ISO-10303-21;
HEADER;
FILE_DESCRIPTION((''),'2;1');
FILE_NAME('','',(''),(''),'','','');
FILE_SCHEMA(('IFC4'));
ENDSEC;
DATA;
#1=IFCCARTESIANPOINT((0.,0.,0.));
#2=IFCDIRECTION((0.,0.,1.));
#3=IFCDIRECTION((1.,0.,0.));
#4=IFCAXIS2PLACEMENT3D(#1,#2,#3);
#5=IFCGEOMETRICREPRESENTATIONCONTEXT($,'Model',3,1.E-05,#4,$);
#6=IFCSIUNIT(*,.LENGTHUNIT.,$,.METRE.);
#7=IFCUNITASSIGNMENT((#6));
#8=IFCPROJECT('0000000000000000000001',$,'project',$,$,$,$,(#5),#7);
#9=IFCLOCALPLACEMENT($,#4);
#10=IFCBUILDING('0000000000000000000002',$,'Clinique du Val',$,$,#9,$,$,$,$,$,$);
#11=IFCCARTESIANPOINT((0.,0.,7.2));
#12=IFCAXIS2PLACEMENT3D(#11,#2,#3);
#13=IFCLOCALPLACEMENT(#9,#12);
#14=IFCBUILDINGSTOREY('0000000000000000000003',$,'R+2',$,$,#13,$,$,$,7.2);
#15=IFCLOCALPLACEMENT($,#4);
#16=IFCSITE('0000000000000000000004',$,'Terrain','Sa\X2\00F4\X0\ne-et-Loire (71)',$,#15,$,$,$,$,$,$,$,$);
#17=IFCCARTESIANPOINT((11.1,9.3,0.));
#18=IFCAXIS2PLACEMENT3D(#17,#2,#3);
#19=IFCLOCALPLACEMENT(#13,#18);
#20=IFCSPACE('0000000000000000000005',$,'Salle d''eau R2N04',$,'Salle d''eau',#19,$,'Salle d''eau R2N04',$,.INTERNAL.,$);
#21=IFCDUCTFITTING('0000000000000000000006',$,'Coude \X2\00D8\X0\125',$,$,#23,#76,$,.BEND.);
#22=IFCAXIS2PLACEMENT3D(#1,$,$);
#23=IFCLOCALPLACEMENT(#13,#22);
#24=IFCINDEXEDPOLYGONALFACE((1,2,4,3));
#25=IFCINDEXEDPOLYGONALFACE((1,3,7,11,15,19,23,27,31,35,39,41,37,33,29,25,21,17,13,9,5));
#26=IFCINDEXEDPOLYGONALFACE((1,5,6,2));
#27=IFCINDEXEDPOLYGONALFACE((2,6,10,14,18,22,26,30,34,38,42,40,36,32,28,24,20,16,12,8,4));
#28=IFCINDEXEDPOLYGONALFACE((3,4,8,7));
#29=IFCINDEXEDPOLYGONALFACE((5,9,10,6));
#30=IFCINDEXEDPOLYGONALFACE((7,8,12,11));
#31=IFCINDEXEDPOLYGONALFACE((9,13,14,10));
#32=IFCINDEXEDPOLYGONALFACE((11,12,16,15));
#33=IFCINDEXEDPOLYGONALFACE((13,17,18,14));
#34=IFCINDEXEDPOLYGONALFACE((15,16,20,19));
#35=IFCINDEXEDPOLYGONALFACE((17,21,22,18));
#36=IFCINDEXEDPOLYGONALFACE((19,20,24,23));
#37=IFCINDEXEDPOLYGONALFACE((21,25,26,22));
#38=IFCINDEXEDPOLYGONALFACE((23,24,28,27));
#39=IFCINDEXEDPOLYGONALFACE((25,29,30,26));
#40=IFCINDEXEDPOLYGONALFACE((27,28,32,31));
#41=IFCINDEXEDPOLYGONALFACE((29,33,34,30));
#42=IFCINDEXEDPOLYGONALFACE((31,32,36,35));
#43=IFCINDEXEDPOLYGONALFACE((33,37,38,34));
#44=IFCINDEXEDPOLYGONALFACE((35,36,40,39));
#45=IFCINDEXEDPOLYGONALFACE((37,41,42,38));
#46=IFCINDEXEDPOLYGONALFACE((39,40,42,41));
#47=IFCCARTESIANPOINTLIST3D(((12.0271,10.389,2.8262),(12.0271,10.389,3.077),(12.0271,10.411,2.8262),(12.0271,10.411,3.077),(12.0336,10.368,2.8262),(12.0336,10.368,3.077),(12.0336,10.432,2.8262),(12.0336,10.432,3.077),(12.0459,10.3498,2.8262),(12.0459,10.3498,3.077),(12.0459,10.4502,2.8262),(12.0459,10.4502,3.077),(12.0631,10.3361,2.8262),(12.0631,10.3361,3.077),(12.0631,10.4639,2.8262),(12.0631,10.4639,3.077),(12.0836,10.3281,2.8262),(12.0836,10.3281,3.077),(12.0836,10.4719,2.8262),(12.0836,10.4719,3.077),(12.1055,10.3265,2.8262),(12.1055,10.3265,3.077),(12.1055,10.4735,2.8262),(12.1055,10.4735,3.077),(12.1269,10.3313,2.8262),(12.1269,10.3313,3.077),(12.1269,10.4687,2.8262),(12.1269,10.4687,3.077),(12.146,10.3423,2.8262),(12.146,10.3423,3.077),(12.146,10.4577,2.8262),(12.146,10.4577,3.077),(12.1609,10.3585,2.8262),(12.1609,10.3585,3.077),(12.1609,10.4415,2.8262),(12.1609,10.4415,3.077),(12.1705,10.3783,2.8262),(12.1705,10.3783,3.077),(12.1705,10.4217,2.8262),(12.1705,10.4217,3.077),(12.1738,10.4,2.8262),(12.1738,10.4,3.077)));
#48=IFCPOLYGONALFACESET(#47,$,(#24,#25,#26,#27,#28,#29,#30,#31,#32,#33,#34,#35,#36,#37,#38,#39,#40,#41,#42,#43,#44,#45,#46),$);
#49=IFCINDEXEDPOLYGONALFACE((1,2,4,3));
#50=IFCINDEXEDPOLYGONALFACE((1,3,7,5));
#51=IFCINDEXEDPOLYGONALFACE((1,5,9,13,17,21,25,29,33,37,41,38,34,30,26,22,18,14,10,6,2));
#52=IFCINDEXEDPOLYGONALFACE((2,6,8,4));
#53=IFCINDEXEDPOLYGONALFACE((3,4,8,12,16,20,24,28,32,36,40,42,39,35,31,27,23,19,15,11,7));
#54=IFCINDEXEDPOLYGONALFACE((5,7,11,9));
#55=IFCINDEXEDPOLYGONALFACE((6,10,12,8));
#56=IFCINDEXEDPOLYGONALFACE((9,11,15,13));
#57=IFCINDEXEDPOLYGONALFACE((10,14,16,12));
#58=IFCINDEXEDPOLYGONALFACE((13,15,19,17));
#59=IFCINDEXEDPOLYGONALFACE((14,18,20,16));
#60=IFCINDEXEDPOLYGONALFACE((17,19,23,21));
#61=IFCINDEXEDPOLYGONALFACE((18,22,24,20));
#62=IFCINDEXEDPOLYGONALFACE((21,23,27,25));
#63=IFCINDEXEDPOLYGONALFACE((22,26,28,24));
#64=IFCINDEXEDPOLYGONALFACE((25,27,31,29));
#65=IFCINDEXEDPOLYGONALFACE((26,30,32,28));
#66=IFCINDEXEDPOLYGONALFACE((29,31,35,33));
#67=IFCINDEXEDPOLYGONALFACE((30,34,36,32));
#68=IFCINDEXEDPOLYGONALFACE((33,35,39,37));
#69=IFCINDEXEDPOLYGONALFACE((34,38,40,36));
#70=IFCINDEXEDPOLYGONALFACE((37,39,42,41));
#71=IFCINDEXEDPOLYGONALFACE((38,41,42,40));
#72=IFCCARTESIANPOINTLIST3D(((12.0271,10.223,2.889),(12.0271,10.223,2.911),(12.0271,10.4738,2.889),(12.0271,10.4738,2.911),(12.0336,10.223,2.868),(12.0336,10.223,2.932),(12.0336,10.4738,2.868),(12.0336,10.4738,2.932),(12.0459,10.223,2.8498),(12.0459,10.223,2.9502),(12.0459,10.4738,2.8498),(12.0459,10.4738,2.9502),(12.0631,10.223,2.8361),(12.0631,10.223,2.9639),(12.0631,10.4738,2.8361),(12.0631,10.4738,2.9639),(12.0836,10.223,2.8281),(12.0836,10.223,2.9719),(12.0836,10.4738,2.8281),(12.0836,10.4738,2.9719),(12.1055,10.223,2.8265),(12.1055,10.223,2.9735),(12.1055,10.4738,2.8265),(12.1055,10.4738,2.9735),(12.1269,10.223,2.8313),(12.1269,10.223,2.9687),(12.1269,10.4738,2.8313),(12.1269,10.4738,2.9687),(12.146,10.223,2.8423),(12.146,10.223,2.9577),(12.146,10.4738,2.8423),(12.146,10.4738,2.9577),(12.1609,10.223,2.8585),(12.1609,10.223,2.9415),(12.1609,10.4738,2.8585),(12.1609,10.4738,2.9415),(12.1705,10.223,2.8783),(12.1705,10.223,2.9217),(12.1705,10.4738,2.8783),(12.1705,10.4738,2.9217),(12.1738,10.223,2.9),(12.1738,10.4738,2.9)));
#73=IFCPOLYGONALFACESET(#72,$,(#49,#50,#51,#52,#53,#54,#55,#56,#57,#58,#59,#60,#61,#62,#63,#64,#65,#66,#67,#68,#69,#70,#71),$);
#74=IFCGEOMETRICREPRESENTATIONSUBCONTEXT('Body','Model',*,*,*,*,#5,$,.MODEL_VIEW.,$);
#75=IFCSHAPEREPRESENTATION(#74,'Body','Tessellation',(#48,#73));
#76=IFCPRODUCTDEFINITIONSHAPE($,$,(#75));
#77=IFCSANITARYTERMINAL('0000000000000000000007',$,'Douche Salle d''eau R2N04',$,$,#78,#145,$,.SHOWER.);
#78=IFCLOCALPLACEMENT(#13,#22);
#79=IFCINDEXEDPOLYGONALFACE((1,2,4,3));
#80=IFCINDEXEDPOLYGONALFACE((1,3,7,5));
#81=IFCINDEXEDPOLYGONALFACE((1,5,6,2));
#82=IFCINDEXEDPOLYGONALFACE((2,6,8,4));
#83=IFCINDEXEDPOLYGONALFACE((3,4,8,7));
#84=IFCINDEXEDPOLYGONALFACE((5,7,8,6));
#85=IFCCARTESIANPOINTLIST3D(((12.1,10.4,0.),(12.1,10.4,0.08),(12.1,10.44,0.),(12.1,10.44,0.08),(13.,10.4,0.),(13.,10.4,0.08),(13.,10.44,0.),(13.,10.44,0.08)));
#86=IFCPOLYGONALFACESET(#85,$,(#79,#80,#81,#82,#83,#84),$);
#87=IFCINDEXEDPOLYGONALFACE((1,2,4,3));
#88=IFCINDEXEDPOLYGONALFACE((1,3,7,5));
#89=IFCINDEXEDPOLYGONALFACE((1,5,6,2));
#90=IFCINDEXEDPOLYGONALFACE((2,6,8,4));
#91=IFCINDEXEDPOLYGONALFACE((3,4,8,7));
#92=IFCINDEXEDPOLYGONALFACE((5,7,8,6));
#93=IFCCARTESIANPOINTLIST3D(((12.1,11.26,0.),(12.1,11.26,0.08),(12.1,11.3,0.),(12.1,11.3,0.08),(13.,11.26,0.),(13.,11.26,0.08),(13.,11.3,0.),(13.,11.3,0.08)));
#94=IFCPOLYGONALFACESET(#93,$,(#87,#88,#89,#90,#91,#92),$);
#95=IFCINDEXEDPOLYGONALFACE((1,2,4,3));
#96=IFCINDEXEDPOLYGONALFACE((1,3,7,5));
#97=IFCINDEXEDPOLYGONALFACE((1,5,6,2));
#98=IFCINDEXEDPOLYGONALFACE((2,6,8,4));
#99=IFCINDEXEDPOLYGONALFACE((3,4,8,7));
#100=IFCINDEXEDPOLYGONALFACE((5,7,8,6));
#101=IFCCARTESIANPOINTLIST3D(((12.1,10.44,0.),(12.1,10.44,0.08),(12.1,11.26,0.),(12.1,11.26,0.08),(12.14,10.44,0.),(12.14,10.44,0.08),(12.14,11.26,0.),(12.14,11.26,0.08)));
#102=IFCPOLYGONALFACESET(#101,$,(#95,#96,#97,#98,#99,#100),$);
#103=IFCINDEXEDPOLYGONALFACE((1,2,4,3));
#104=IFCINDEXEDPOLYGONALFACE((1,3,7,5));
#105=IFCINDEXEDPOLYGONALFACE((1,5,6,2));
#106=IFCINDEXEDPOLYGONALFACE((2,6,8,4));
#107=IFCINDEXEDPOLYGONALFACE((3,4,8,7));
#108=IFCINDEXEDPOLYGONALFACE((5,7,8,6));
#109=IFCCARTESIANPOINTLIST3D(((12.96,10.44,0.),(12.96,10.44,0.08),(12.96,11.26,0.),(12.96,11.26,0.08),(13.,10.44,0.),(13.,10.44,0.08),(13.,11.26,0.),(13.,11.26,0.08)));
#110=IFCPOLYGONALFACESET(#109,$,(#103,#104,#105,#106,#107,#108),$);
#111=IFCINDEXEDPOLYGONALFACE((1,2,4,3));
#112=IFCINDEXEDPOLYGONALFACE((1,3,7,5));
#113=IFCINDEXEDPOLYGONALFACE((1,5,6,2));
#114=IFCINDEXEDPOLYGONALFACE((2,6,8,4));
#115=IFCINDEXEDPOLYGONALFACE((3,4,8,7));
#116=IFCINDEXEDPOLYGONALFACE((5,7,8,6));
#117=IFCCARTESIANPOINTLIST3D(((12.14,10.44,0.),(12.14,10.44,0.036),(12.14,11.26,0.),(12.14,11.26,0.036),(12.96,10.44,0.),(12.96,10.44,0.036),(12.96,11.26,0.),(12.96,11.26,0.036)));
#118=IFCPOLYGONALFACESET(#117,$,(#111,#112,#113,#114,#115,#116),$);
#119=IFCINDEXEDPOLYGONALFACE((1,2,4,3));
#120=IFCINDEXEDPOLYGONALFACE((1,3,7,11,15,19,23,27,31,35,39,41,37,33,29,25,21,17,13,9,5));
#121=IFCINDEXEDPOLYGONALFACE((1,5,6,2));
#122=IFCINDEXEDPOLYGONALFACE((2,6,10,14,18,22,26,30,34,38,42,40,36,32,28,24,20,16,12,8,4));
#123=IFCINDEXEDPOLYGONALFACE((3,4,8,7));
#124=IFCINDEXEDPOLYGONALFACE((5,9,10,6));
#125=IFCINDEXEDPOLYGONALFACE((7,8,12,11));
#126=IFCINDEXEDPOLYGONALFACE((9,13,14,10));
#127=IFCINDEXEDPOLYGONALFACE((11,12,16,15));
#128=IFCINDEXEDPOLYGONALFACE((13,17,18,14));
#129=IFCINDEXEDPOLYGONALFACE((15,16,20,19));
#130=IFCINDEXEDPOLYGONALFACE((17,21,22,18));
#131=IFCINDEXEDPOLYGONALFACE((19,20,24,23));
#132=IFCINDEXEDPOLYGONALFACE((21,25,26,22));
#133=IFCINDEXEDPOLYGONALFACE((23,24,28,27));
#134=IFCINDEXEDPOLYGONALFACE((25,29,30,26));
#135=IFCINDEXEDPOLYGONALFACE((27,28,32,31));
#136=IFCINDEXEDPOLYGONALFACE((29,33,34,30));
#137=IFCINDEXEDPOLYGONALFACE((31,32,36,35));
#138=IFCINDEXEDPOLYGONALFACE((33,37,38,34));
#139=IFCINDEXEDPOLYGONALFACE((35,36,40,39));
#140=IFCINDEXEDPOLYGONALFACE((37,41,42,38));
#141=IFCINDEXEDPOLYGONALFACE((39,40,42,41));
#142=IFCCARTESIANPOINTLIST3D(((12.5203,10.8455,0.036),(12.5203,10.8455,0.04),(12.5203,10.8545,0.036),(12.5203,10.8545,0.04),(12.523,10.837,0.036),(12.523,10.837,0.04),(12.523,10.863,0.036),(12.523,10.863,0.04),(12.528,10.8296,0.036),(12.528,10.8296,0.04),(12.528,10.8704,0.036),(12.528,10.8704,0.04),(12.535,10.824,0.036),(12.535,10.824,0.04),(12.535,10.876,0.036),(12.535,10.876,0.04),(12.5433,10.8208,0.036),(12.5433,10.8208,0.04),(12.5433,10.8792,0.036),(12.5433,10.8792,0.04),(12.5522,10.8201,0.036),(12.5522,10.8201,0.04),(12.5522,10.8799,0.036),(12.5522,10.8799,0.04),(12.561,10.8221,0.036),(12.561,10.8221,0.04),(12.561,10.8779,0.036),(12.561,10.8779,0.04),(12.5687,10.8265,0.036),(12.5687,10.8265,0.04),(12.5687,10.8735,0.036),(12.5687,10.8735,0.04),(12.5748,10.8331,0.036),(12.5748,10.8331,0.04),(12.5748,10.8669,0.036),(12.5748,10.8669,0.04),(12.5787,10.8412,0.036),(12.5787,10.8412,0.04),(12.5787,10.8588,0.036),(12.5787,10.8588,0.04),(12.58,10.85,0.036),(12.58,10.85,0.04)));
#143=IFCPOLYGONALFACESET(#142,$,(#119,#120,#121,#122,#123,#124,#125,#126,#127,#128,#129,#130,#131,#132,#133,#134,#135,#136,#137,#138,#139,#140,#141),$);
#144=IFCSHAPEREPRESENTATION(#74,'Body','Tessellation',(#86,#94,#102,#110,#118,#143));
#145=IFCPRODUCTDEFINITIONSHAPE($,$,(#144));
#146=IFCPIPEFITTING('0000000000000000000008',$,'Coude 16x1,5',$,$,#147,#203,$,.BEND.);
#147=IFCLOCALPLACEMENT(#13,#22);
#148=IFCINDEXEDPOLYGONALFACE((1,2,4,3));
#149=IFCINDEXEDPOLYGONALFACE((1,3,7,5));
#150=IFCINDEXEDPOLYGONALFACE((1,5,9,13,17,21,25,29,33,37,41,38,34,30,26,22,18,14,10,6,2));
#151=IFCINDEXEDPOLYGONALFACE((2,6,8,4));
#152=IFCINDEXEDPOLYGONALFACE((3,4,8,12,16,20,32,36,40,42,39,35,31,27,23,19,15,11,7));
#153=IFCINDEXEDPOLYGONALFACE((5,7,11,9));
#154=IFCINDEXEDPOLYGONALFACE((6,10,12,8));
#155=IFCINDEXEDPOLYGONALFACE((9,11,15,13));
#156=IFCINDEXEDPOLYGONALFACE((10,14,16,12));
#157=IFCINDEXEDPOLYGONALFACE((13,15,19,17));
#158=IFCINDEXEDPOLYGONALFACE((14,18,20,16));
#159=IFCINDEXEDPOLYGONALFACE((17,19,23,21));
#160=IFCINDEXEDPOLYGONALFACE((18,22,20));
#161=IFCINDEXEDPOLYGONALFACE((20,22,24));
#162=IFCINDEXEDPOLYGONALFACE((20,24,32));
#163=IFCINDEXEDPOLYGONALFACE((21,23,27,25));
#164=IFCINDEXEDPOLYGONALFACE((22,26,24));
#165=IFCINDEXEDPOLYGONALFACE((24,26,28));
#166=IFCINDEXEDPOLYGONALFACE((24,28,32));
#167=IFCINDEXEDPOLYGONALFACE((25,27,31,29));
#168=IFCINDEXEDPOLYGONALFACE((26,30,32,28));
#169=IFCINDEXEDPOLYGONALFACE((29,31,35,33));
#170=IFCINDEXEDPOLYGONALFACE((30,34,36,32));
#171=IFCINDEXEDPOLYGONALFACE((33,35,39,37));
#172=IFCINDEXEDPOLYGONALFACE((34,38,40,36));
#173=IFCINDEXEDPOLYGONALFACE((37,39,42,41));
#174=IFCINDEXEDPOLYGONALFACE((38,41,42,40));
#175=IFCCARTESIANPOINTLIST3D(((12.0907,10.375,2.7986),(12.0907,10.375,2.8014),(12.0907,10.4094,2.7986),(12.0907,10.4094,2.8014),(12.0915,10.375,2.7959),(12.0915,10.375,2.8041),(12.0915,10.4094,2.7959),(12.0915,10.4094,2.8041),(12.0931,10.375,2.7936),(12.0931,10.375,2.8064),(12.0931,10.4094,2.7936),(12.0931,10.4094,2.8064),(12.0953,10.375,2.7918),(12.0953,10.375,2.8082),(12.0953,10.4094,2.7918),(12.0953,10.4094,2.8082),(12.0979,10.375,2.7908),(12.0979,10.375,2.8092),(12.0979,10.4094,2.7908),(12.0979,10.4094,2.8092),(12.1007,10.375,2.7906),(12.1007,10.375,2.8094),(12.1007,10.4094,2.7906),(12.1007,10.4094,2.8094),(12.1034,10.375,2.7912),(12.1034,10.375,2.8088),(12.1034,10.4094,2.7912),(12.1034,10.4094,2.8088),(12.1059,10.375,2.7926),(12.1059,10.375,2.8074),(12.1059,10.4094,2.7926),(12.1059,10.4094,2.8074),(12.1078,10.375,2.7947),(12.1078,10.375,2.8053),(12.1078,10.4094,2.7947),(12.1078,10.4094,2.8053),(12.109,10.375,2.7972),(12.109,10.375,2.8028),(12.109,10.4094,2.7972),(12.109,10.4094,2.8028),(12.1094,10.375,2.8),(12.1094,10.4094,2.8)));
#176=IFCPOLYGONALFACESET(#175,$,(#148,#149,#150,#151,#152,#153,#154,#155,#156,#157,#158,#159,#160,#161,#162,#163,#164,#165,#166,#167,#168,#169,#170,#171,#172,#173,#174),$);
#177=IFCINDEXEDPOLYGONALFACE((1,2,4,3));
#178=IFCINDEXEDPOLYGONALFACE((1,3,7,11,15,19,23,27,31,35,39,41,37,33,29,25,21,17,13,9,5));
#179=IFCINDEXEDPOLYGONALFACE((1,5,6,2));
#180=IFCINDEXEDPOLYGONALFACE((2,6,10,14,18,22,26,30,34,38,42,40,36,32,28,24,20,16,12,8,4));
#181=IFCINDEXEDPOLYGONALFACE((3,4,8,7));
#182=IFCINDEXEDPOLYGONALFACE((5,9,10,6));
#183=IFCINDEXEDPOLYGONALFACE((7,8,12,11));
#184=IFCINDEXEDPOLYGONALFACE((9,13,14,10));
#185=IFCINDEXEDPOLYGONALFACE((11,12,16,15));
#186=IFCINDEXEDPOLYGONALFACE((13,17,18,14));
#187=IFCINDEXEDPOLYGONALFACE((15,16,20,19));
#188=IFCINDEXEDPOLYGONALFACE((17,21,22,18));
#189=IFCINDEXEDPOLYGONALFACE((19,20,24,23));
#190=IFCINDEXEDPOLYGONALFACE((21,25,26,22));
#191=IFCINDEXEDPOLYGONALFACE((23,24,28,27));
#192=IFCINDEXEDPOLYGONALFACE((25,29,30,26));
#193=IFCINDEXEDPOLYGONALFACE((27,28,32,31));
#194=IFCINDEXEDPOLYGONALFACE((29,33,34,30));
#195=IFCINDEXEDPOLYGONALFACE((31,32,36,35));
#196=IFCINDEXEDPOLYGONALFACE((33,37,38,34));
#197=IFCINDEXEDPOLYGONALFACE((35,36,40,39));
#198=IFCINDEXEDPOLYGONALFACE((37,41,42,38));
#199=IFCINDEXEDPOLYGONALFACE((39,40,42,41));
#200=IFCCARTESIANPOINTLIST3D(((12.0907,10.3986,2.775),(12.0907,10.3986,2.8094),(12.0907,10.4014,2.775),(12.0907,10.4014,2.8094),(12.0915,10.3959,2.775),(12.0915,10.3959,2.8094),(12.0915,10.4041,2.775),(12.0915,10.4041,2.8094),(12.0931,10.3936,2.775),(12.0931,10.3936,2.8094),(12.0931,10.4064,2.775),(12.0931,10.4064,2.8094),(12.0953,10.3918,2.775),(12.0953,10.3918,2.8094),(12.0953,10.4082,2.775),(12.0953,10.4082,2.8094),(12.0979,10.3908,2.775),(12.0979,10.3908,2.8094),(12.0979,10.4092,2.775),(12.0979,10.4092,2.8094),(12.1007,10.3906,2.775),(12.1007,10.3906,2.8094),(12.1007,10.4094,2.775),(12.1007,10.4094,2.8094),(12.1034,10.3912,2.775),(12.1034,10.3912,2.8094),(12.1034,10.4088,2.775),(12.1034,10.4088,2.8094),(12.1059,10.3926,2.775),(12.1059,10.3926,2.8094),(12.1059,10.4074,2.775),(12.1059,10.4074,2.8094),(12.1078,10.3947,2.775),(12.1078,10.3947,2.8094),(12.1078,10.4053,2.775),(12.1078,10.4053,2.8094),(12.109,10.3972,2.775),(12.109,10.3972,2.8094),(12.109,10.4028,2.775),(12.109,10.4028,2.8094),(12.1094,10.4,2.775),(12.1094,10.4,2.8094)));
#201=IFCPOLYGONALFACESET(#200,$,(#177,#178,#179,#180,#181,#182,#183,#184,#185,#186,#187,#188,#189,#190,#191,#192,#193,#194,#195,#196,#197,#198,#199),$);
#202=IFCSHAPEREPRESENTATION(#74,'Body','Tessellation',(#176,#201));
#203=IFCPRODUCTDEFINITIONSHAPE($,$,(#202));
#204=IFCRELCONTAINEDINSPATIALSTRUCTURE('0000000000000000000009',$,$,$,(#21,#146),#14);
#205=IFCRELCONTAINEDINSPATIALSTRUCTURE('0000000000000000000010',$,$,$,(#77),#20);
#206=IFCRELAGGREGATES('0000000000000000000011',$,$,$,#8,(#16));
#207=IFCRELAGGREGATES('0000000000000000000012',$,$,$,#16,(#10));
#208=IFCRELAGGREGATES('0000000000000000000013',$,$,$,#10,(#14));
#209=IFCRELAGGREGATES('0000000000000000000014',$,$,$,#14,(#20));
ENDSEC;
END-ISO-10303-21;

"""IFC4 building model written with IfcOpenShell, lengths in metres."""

from ifc_helpers import new_model, si_unit, frame, frame_2d, origin_with_axes, place, context, subcontext, project, spatial, rectangle, circle, extrude, element, save


model = new_model("IFC4")

# Units and contexts
model_context = context("Model", 3, precision=1e-05, world=origin_with_axes())
body_context = subcontext(model_context, "Body", "Model", "MODEL_VIEW")
ifc_project = project(units=[si_unit("LENGTHUNIT", "METRE")], contexts=[model_context])

# Site, building, storey
site_placement = place(None, origin_with_axes())
site = spatial("IfcSite", under=ifc_project, at=site_placement, Name="Terrain", Description="Saône-et-Loire (71)")
building_placement = place(None, origin_with_axes())
building = spatial("IfcBuilding", under=site, at=building_placement, Name="Clinique du Val")
storey_placement = place(building_placement, frame((0.0, 0.0, 7.2), z_axis=(0.0, 0.0, 1.0), x_axis=(1.0, 0.0, 0.0)))
storey = spatial("IfcBuildingStorey", under=building, at=storey_placement, Name="R+2", Elevation=7.2)

# Shared definitions
space_1_placement = place(storey_placement, frame((11.1, 9.3, 0.0), z_axis=(0.0, 0.0, 1.0), x_axis=(1.0, 0.0, 0.0)))
space_1 = spatial("IfcSpace", under=storey, at=space_1_placement, Name="Salle d'eau R2N04", ObjectType="Salle d'eau", LongName="Salle d'eau R2N04", PredefinedType="INTERNAL")

# Duct fitting
duct_fitting_placement = place(storey_placement, frame((12.1, 10.4, 2.9), z_axis=(0.0, 0.0, 1.0), x_axis=(1.0, 0.0, 0.0)))
element("IfcDuctFitting", 1, at=duct_fitting_placement, inside=storey, Name="Coude Ø125", PredefinedType="BEND", context=body_context, shape_type="SweptSolid", body=[
    extrude(circle(Radius=0.0737), frame((0.0, 0.0, -0.0737), z_axis=(0.0, 0.0, 1.0), x_axis=(1.0, 0.0, 0.0)), (0.0, 0.0, 1.0), 0.2507),
    extrude(circle(Radius=0.0737), frame((0.0, 0.0737, 0.0), z_axis=(0.0, -1.0, 0.0), x_axis=(1.0, 0.0, 0.0)), (0.0, 0.0, 1.0), 0.2507),
])

# Sanitary terminal
sanitary_terminal_1_placement = place(space_1_placement, frame((1.0, 1.1, 0.0), z_axis=(0.0, 0.0, 1.0), x_axis=(1.0, 0.0, 0.0)))
element("IfcSanitaryTerminal", 2, at=sanitary_terminal_1_placement, inside=space_1, Name="Douche Salle d'eau R2N04", PredefinedType="SHOWER", context=body_context, shape_type="SweptSolid", body=[
    extrude(rectangle(XDim=0.9, YDim=0.04, at=frame_2d((0.45, 0.02))), origin_with_axes(), (0.0, 0.0, 1.0), 0.08),
    extrude(rectangle(XDim=0.9, YDim=0.04, at=frame_2d((0.45, 0.02))), frame((0.0, 0.86, 0.0), z_axis=(0.0, 0.0, 1.0), x_axis=(1.0, 0.0, 0.0)), (0.0, 0.0, 1.0), 0.08),
    extrude(rectangle(XDim=0.04, YDim=0.82, at=frame_2d((0.02, 0.41))), frame((0.0, 0.04, 0.0), z_axis=(0.0, 0.0, 1.0), x_axis=(1.0, 0.0, 0.0)), (0.0, 0.0, 1.0), 0.08),
    extrude(rectangle(XDim=0.04, YDim=0.82, at=frame_2d((0.02, 0.41))), frame((0.86, 0.04, 0.0), z_axis=(0.0, 0.0, 1.0), x_axis=(1.0, 0.0, 0.0)), (0.0, 0.0, 1.0), 0.08),
    extrude(rectangle(XDim=0.82, YDim=0.82, at=frame_2d((0.41, 0.41))), frame((0.04, 0.04, 0.0), z_axis=(0.0, 0.0, 1.0), x_axis=(1.0, 0.0, 0.0)), (0.0, 0.0, 1.0), 0.036),
    extrude(circle(Radius=0.03), frame((0.45, 0.45, 0.036), z_axis=(0.0, 0.0, 1.0), x_axis=(1.0, 0.0, 0.0)), (0.0, 0.0, 1.0), 0.004),
])

# Pipe fitting
for number, where, z_axis, x_axis, name in (
    (3, (12.1, 10.4, 2.8), (0.0, 0.0, 1.0), (1.0, 0.0, 0.0), "Coude 16x1,5"),
):
    element("IfcPipeFitting", number, at=place(storey_placement, frame(where, z_axis=z_axis, x_axis=x_axis)), inside=storey, Name=name, PredefinedType="BEND", context=body_context, shape_type="SweptSolid", body=[
        extrude(circle(Radius=0.0094), frame((0.0, 0.0094, 0.0), z_axis=(0.0, -1.0, 0.0), x_axis=(1.0, 0.0, 0.0)), (0.0, 0.0, 1.0), 0.0344),
        extrude(circle(Radius=0.0094), frame((0.0, 0.0, 0.0094), z_axis=(0.0, 0.0, -1.0), x_axis=(1.0, 0.0, 0.0)), (0.0, 0.0, 1.0), 0.0344),
    ])

save(model, "model.ifc")
